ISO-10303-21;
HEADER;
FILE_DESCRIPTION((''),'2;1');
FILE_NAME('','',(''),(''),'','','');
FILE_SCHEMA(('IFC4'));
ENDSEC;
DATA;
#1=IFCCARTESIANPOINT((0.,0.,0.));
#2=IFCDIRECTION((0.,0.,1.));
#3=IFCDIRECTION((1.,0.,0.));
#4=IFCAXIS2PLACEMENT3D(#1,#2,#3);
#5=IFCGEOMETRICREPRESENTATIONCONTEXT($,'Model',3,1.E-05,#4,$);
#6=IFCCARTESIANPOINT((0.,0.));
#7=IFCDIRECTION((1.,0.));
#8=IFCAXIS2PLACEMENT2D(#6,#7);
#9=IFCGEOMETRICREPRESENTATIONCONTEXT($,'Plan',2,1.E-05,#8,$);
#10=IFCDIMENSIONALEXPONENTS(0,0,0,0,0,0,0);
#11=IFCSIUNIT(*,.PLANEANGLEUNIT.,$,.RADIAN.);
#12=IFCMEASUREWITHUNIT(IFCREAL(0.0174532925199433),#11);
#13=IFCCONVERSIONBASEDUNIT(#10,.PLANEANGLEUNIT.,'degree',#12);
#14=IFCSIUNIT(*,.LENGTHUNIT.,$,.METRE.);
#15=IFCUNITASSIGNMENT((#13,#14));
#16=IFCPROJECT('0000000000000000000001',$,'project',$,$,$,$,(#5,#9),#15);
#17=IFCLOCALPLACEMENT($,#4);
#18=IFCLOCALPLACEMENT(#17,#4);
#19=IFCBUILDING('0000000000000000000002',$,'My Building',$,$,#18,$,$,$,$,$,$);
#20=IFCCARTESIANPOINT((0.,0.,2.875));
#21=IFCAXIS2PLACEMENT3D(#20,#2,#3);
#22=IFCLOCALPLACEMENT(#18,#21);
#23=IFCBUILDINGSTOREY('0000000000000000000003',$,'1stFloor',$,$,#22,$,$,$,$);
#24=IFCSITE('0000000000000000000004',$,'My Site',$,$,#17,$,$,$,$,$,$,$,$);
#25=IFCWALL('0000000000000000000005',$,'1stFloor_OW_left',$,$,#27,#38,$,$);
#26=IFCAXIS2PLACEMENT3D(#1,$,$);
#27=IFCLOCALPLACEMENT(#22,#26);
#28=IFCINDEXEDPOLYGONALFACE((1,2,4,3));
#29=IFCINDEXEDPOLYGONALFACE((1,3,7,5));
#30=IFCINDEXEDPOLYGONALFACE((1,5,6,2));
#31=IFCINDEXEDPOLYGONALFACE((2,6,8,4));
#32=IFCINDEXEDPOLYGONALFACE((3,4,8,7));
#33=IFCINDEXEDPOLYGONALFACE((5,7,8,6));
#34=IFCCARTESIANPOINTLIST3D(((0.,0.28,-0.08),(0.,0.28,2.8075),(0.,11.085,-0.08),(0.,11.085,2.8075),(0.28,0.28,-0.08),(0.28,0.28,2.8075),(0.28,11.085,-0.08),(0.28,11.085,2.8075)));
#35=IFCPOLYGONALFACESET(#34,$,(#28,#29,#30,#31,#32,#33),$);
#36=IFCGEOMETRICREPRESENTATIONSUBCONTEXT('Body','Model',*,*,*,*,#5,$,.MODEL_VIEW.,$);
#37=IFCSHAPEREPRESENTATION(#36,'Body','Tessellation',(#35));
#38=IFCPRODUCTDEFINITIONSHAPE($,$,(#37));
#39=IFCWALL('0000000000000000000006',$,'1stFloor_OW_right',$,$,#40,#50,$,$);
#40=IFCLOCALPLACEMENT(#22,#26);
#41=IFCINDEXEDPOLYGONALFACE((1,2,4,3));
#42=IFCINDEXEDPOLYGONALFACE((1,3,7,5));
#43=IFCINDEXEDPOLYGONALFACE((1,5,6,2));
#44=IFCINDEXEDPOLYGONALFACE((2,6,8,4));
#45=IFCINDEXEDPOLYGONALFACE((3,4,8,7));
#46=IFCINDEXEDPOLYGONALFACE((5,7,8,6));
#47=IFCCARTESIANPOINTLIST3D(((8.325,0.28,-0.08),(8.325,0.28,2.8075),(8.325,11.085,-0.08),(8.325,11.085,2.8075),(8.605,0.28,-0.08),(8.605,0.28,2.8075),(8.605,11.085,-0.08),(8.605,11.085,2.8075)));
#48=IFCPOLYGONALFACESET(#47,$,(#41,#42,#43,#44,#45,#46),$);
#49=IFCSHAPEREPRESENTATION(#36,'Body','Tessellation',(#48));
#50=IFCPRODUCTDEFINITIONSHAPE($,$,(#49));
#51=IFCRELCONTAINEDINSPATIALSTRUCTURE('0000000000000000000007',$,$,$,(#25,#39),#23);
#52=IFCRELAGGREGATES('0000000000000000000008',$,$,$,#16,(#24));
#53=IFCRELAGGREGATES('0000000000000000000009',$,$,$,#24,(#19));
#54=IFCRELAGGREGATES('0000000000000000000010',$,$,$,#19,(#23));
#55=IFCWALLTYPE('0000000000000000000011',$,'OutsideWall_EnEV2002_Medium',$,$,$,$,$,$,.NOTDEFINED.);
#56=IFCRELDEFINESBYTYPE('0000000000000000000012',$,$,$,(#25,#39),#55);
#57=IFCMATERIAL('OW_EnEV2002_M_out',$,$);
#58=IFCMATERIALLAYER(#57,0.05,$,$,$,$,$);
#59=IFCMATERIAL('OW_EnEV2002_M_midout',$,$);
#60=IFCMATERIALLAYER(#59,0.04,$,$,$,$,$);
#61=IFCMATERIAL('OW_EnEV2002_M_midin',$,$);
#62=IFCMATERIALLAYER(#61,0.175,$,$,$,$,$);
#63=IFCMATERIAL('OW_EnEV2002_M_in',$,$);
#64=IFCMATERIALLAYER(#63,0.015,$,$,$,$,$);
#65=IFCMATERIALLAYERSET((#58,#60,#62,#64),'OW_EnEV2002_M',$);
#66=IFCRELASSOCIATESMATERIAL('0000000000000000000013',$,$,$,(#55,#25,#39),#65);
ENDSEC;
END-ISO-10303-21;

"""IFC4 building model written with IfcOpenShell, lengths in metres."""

from ifc_helpers import new_model, entity, si_unit, converted_unit, frame, origin_with_axes, origin_2d_with_axis, place, context, subcontext, project, spatial, indexed_curve, outline, extrude, material, layer, layer_set, layer_usage, type_object, element, save


model = new_model("IFC4")

# Units and contexts
model_context = context("Model", 3, precision=1e-05, world=origin_with_axes())
plan_context = context("Plan", 2, precision=1e-05, world=origin_2d_with_axis())
body_context = subcontext(model_context, "Body", "Model", "MODEL_VIEW")
ifc_project = project(units=[converted_unit("PLANEANGLEUNIT", "degree", entity("IfcReal", 0.0174532925199433), si_unit("PLANEANGLEUNIT", "RADIAN"), dimensions=[0, 0, 0, 0, 0, 0, 0]), si_unit("LENGTHUNIT", "METRE")], contexts=[model_context, plan_context])

# Site, building, storey
site_placement = place(None, origin_with_axes())
site = spatial("IfcSite", under=ifc_project, at=site_placement, Name="My Site")
building_placement = place(site_placement, origin_with_axes())
building = spatial("IfcBuilding", under=site, at=building_placement, Name="My Building")
storey_placement = place(building_placement, frame((0.0, 0.0, 2.875), z_axis=(0.0, 0.0, 1.0), x_axis=(1.0, 0.0, 0.0)))
storey = spatial("IfcBuildingStorey", under=building, at=storey_placement, Name="1stFloor")

# Shared definitions
ifc_material_1 = material(Name="OW_EnEV2002_M_out")
ifc_layer_1 = layer(ifc_material_1, 0.05)
ifc_material_2 = material(Name="OW_EnEV2002_M_midout")
ifc_layer_2 = layer(ifc_material_2, 0.04)
ifc_material_3 = material(Name="OW_EnEV2002_M_midin")
ifc_layer_3 = layer(ifc_material_3, 0.175)
ifc_material_4 = material(Name="OW_EnEV2002_M_in")
ifc_layer_4 = layer(ifc_material_4, 0.015)
ifc_layer_set_1 = layer_set([ifc_layer_1, ifc_layer_2, ifc_layer_3, ifc_layer_4], Name="OW_EnEV2002_M")
wall_type_1 = type_object("IfcWallType", Name="OutsideWall_EnEV2002_Medium", PredefinedType="NOTDEFINED", material=ifc_layer_set_1)

# Walls
ifc_layer_usage_1 = layer_usage(ifc_layer_set_1, "AXIS2", "POSITIVE", 0.0)
wall_1_placement = place(storey_placement, frame((0.0, 11.085, -0.08), z_axis=(0.0, 0.0, 1.0), x_axis=(-0.000001, -1.0, 0.0)))
element("IfcWall", 1, at=wall_1_placement, inside=storey, type_object=wall_type_1, material=ifc_layer_usage_1, Name="1stFloor_OW_left", context=body_context, shape_type="SweptSolid", body=[
    extrude(outline(indexed_curve([(0.0, 0.0), (0.0, 0.28), (10.805, 0.28), (10.805, 0.0), (0.0, 0.0)], self_intersect=False)), origin_with_axes(), (0.0, 0.0, 1.0), 2.8875),
])
ifc_layer_usage_2 = layer_usage(ifc_layer_set_1, "AXIS2", "POSITIVE", 0.0)
wall_2_placement = place(storey_placement, frame((8.605, 0.28, -0.08), z_axis=(0.0, 0.0, 1.0), x_axis=(0.0, 1.0, 0.0)))
element("IfcWall", 2, at=wall_2_placement, inside=storey, type_object=wall_type_1, material=ifc_layer_usage_2, Name="1stFloor_OW_right", context=body_context, shape_type="SweptSolid", body=[
    extrude(outline(indexed_curve([(0.0, 0.0), (0.0, 0.28), (10.805, 0.28), (10.805, 0.0), (0.0, 0.0)], self_intersect=False)), origin_with_axes(), (0.0, 0.0, 1.0), 2.8875),
])

save(model, "model.ifc")
